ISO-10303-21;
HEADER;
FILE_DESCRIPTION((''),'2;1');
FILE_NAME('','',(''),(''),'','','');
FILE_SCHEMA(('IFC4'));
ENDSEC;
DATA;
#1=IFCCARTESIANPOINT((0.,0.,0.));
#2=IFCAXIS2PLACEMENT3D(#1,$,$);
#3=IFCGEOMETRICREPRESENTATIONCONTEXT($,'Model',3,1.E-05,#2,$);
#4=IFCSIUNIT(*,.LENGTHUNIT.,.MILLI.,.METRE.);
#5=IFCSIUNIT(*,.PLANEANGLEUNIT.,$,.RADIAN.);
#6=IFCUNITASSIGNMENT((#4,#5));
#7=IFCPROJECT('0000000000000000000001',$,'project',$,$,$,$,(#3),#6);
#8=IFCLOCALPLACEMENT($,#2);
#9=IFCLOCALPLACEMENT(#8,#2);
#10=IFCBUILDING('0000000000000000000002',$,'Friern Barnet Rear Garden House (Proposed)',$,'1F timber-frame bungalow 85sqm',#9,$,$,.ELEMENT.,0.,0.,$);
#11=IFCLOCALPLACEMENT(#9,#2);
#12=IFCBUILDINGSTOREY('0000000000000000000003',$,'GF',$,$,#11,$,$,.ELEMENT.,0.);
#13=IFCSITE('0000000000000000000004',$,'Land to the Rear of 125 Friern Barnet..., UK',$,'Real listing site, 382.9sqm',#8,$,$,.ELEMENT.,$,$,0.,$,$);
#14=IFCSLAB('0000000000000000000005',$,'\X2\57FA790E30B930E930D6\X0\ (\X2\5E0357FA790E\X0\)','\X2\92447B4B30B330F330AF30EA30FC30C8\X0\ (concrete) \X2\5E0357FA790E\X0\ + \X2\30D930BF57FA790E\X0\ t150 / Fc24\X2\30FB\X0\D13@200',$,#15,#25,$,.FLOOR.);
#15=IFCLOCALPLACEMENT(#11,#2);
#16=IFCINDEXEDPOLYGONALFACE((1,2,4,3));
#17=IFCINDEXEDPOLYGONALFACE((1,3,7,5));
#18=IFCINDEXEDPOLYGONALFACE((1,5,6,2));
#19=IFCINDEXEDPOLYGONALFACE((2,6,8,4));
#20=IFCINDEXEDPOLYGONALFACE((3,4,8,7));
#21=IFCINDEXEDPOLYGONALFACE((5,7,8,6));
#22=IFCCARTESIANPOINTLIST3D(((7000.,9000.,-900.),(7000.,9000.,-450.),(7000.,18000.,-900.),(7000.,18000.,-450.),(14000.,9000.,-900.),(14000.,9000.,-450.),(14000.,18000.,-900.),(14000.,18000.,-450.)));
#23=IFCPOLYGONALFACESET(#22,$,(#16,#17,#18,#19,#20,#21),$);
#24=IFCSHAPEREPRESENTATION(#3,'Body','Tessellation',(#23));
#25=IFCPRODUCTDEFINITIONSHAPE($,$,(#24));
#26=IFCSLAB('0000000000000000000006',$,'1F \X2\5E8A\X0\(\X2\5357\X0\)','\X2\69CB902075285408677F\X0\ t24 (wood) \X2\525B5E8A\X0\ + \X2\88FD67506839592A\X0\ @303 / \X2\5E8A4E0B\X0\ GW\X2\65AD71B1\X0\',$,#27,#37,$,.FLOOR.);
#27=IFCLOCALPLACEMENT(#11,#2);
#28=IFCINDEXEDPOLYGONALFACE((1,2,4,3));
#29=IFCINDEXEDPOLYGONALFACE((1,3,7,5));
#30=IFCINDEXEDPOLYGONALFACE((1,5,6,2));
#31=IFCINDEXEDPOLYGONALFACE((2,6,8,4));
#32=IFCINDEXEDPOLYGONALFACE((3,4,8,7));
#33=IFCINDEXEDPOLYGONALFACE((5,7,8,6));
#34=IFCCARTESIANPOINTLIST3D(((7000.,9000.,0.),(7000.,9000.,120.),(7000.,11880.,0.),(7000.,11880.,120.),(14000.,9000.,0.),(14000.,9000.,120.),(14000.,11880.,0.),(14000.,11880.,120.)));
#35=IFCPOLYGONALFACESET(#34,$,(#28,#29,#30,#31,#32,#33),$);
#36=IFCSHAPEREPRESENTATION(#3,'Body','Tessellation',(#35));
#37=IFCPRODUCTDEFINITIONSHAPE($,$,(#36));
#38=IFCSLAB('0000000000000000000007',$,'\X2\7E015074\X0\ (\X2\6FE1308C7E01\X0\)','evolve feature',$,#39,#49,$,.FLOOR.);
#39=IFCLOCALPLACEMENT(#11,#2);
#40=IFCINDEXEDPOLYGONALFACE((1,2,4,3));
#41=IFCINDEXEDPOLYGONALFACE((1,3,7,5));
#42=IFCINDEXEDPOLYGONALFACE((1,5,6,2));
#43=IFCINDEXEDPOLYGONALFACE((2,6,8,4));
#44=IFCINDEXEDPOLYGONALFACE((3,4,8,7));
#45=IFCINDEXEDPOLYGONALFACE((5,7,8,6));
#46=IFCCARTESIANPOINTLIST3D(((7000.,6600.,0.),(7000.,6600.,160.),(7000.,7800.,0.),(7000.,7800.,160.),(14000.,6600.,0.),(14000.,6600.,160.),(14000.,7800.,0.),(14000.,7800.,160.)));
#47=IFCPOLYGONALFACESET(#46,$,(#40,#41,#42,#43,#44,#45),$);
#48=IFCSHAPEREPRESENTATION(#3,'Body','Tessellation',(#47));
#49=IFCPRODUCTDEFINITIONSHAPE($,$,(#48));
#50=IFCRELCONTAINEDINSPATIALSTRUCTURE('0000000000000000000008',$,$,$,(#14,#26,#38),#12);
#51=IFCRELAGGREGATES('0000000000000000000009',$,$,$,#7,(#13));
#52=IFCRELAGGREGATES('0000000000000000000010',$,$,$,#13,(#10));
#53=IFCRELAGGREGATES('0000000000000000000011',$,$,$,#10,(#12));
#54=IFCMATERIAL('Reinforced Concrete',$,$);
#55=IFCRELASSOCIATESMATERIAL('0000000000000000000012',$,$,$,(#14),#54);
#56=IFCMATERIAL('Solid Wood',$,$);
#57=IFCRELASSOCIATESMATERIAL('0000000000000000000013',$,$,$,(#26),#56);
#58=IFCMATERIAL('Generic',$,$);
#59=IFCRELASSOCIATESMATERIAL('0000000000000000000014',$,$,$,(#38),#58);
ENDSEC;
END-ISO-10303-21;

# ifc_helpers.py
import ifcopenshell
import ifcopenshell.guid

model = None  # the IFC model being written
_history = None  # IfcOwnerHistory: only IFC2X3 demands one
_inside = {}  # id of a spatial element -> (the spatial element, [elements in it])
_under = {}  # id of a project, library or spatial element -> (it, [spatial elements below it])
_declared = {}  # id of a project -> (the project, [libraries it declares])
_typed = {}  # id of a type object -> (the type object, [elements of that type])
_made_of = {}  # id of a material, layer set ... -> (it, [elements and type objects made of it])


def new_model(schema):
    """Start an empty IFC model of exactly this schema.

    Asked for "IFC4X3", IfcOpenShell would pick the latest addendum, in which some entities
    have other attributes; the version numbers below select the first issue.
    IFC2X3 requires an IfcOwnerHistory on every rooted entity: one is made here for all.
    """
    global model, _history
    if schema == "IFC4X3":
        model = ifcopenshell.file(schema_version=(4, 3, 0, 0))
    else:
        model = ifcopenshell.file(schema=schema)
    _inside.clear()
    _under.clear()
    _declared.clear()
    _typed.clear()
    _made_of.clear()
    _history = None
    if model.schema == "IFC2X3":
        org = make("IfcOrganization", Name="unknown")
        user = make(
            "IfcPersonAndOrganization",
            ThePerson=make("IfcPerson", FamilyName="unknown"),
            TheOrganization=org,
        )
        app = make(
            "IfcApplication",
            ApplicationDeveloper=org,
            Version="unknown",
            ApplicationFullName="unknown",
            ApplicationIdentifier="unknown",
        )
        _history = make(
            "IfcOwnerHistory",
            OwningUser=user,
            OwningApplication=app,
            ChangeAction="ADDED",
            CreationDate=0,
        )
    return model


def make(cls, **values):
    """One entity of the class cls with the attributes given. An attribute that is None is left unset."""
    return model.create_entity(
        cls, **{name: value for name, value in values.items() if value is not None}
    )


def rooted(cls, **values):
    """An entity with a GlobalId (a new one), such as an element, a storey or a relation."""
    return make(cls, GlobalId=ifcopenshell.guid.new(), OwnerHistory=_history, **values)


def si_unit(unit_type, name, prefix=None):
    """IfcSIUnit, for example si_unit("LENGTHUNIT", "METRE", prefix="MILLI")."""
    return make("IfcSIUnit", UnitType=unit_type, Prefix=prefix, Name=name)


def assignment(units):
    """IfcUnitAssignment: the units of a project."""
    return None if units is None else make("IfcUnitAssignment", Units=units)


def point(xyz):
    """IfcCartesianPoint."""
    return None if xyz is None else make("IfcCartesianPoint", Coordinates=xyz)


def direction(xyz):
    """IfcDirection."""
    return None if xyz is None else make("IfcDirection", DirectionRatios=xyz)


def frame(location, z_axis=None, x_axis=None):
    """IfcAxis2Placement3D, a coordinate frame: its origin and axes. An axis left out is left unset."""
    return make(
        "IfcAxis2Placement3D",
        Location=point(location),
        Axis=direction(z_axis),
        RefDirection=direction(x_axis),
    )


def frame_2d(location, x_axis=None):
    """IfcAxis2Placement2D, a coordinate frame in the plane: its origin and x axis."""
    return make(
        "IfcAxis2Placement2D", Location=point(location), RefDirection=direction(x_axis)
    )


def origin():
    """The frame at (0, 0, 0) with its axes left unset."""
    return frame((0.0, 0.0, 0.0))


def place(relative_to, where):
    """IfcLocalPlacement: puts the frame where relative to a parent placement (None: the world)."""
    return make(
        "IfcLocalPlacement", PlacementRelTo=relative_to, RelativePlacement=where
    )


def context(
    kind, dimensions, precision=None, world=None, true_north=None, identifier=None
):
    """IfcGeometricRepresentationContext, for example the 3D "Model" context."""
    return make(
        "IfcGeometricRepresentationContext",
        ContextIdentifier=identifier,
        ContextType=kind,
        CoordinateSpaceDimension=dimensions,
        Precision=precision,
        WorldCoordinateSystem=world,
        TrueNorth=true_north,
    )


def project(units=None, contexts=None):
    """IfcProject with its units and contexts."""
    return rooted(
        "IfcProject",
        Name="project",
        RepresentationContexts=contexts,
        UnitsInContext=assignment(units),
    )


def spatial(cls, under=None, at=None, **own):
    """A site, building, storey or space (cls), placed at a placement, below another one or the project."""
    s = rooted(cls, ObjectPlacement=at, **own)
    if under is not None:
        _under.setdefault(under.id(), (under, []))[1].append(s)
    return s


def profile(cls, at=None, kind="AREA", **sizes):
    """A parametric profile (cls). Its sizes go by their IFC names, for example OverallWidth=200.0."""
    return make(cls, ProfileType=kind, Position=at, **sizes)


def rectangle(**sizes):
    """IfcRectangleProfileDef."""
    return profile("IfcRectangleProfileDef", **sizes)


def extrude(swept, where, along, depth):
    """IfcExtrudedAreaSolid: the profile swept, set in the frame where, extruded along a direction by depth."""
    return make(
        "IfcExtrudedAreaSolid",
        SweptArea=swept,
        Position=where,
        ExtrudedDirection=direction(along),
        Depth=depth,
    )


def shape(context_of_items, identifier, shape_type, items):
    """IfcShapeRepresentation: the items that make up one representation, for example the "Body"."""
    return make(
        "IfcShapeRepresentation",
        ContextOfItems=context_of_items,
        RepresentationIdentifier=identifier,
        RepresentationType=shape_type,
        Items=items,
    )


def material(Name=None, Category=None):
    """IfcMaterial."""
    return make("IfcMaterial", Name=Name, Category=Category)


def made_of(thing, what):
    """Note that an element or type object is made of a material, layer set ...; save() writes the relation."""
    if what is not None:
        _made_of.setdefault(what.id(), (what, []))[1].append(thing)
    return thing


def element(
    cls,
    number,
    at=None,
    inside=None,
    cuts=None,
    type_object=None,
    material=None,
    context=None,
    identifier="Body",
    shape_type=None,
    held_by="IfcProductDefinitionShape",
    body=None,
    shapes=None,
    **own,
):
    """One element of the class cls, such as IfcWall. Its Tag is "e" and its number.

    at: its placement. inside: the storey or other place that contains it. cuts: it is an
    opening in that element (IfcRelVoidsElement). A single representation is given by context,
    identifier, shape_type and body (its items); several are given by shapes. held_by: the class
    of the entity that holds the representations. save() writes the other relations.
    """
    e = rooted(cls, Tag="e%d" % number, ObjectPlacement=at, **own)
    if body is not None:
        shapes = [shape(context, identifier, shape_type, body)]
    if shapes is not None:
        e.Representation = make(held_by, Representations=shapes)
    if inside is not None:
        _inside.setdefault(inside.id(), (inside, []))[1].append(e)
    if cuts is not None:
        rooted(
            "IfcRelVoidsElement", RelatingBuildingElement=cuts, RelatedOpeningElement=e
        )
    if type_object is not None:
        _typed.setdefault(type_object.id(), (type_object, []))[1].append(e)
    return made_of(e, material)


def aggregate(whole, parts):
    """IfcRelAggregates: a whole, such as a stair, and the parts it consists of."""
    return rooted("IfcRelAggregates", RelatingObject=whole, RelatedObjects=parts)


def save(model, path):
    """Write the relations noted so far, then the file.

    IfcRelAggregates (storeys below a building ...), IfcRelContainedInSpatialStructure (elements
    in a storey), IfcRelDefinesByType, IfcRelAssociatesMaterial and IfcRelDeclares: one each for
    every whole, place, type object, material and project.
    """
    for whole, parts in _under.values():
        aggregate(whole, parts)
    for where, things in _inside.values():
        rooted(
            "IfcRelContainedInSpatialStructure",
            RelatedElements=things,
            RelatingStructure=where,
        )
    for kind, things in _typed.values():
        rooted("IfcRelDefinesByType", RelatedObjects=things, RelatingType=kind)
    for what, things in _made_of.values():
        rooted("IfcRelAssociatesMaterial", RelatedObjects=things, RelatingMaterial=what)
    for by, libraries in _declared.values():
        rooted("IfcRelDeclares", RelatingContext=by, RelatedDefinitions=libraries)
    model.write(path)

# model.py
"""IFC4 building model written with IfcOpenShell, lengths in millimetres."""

from ifc_helpers import new_model, si_unit, frame, frame_2d, origin, place, context, project, spatial, rectangle, extrude, material, element, save


model = new_model("IFC4")

# Units and contexts
model_context = context("Model", 3, precision=1e-05, world=origin())
ifc_project = project(units=[si_unit("LENGTHUNIT", "METRE", prefix="MILLI"), si_unit("PLANEANGLEUNIT", "RADIAN")], contexts=[model_context])

# Site, building, storey
site_placement = place(None, origin())
site = spatial("IfcSite", under=ifc_project, at=site_placement, Name="Land to the Rear of 125 Friern Barnet..., UK", ObjectType="Real listing site, 382.9sqm", CompositionType="ELEMENT", RefElevation=0.0)
building_placement = place(site_placement, origin())
building = spatial("IfcBuilding", under=site, at=building_placement, Name="Friern Barnet Rear Garden House (Proposed)", ObjectType="1F timber-frame bungalow 85sqm", CompositionType="ELEMENT", ElevationOfRefHeight=0.0, ElevationOfTerrain=0.0)
storey_placement = place(building_placement, origin())
storey = spatial("IfcBuildingStorey", under=building, at=storey_placement, Name="GF", CompositionType="ELEMENT", Elevation=0.0)

# Slabs
ifc_material_1 = material(Name="Reinforced Concrete")
slab_1_placement = place(storey_placement, frame((3500.0, 4500.0, -450.0)))
element("IfcSlab", 1, at=slab_1_placement, inside=storey, material=ifc_material_1, Name="基礎スラブ (布基礎)", Description="鉄筋コンクリート (concrete) 布基礎 + ベタ基礎 t150 / Fc24・D13@200", PredefinedType="FLOOR", context=model_context, shape_type="SweptSolid", body=[
    extrude(rectangle(XDim=7000.0, YDim=9000.0, at=frame_2d((3500.0, 4500.0))), frame((3500.0, 4500.0, -450.0)), (0.0, 0.0, 1.0), 450.0),
])
ifc_material_2 = material(Name="Solid Wood")
slab_2_placement = place(storey_placement, frame((3500.0, 4500.0, 0.0)))
element("IfcSlab", 2, at=slab_2_placement, inside=storey, material=ifc_material_2, Name="1F 床(南)", Description="構造用合板 t24 (wood) 剛床 + 製材根太 @303 / 床下 GW断熱", PredefinedType="FLOOR", context=model_context, shape_type="SweptSolid", body=[
    extrude(rectangle(XDim=7000.0, YDim=2880.0, at=frame_2d((3500.0, 1440.0))), frame((3500.0, 4500.0, 0.0)), (0.0, 0.0, 1.0), 120.0),
])
ifc_material_3 = material(Name="Generic")
slab_3_placement = place(storey_placement, frame((3500.0, 3300.0, 0.0)))
element("IfcSlab", 3, at=slab_3_placement, inside=storey, material=ifc_material_3, Name="縁側 (濡れ縁)", Description="evolve feature", PredefinedType="FLOOR", context=model_context, shape_type="SweptSolid", body=[
    extrude(rectangle(XDim=7000.0, YDim=1200.0, at=frame_2d((3500.0, 600.0))), frame((3500.0, 3300.0, 0.0)), (0.0, 0.0, 1.0), 160.0),
])

save(model, "model.ifc")
